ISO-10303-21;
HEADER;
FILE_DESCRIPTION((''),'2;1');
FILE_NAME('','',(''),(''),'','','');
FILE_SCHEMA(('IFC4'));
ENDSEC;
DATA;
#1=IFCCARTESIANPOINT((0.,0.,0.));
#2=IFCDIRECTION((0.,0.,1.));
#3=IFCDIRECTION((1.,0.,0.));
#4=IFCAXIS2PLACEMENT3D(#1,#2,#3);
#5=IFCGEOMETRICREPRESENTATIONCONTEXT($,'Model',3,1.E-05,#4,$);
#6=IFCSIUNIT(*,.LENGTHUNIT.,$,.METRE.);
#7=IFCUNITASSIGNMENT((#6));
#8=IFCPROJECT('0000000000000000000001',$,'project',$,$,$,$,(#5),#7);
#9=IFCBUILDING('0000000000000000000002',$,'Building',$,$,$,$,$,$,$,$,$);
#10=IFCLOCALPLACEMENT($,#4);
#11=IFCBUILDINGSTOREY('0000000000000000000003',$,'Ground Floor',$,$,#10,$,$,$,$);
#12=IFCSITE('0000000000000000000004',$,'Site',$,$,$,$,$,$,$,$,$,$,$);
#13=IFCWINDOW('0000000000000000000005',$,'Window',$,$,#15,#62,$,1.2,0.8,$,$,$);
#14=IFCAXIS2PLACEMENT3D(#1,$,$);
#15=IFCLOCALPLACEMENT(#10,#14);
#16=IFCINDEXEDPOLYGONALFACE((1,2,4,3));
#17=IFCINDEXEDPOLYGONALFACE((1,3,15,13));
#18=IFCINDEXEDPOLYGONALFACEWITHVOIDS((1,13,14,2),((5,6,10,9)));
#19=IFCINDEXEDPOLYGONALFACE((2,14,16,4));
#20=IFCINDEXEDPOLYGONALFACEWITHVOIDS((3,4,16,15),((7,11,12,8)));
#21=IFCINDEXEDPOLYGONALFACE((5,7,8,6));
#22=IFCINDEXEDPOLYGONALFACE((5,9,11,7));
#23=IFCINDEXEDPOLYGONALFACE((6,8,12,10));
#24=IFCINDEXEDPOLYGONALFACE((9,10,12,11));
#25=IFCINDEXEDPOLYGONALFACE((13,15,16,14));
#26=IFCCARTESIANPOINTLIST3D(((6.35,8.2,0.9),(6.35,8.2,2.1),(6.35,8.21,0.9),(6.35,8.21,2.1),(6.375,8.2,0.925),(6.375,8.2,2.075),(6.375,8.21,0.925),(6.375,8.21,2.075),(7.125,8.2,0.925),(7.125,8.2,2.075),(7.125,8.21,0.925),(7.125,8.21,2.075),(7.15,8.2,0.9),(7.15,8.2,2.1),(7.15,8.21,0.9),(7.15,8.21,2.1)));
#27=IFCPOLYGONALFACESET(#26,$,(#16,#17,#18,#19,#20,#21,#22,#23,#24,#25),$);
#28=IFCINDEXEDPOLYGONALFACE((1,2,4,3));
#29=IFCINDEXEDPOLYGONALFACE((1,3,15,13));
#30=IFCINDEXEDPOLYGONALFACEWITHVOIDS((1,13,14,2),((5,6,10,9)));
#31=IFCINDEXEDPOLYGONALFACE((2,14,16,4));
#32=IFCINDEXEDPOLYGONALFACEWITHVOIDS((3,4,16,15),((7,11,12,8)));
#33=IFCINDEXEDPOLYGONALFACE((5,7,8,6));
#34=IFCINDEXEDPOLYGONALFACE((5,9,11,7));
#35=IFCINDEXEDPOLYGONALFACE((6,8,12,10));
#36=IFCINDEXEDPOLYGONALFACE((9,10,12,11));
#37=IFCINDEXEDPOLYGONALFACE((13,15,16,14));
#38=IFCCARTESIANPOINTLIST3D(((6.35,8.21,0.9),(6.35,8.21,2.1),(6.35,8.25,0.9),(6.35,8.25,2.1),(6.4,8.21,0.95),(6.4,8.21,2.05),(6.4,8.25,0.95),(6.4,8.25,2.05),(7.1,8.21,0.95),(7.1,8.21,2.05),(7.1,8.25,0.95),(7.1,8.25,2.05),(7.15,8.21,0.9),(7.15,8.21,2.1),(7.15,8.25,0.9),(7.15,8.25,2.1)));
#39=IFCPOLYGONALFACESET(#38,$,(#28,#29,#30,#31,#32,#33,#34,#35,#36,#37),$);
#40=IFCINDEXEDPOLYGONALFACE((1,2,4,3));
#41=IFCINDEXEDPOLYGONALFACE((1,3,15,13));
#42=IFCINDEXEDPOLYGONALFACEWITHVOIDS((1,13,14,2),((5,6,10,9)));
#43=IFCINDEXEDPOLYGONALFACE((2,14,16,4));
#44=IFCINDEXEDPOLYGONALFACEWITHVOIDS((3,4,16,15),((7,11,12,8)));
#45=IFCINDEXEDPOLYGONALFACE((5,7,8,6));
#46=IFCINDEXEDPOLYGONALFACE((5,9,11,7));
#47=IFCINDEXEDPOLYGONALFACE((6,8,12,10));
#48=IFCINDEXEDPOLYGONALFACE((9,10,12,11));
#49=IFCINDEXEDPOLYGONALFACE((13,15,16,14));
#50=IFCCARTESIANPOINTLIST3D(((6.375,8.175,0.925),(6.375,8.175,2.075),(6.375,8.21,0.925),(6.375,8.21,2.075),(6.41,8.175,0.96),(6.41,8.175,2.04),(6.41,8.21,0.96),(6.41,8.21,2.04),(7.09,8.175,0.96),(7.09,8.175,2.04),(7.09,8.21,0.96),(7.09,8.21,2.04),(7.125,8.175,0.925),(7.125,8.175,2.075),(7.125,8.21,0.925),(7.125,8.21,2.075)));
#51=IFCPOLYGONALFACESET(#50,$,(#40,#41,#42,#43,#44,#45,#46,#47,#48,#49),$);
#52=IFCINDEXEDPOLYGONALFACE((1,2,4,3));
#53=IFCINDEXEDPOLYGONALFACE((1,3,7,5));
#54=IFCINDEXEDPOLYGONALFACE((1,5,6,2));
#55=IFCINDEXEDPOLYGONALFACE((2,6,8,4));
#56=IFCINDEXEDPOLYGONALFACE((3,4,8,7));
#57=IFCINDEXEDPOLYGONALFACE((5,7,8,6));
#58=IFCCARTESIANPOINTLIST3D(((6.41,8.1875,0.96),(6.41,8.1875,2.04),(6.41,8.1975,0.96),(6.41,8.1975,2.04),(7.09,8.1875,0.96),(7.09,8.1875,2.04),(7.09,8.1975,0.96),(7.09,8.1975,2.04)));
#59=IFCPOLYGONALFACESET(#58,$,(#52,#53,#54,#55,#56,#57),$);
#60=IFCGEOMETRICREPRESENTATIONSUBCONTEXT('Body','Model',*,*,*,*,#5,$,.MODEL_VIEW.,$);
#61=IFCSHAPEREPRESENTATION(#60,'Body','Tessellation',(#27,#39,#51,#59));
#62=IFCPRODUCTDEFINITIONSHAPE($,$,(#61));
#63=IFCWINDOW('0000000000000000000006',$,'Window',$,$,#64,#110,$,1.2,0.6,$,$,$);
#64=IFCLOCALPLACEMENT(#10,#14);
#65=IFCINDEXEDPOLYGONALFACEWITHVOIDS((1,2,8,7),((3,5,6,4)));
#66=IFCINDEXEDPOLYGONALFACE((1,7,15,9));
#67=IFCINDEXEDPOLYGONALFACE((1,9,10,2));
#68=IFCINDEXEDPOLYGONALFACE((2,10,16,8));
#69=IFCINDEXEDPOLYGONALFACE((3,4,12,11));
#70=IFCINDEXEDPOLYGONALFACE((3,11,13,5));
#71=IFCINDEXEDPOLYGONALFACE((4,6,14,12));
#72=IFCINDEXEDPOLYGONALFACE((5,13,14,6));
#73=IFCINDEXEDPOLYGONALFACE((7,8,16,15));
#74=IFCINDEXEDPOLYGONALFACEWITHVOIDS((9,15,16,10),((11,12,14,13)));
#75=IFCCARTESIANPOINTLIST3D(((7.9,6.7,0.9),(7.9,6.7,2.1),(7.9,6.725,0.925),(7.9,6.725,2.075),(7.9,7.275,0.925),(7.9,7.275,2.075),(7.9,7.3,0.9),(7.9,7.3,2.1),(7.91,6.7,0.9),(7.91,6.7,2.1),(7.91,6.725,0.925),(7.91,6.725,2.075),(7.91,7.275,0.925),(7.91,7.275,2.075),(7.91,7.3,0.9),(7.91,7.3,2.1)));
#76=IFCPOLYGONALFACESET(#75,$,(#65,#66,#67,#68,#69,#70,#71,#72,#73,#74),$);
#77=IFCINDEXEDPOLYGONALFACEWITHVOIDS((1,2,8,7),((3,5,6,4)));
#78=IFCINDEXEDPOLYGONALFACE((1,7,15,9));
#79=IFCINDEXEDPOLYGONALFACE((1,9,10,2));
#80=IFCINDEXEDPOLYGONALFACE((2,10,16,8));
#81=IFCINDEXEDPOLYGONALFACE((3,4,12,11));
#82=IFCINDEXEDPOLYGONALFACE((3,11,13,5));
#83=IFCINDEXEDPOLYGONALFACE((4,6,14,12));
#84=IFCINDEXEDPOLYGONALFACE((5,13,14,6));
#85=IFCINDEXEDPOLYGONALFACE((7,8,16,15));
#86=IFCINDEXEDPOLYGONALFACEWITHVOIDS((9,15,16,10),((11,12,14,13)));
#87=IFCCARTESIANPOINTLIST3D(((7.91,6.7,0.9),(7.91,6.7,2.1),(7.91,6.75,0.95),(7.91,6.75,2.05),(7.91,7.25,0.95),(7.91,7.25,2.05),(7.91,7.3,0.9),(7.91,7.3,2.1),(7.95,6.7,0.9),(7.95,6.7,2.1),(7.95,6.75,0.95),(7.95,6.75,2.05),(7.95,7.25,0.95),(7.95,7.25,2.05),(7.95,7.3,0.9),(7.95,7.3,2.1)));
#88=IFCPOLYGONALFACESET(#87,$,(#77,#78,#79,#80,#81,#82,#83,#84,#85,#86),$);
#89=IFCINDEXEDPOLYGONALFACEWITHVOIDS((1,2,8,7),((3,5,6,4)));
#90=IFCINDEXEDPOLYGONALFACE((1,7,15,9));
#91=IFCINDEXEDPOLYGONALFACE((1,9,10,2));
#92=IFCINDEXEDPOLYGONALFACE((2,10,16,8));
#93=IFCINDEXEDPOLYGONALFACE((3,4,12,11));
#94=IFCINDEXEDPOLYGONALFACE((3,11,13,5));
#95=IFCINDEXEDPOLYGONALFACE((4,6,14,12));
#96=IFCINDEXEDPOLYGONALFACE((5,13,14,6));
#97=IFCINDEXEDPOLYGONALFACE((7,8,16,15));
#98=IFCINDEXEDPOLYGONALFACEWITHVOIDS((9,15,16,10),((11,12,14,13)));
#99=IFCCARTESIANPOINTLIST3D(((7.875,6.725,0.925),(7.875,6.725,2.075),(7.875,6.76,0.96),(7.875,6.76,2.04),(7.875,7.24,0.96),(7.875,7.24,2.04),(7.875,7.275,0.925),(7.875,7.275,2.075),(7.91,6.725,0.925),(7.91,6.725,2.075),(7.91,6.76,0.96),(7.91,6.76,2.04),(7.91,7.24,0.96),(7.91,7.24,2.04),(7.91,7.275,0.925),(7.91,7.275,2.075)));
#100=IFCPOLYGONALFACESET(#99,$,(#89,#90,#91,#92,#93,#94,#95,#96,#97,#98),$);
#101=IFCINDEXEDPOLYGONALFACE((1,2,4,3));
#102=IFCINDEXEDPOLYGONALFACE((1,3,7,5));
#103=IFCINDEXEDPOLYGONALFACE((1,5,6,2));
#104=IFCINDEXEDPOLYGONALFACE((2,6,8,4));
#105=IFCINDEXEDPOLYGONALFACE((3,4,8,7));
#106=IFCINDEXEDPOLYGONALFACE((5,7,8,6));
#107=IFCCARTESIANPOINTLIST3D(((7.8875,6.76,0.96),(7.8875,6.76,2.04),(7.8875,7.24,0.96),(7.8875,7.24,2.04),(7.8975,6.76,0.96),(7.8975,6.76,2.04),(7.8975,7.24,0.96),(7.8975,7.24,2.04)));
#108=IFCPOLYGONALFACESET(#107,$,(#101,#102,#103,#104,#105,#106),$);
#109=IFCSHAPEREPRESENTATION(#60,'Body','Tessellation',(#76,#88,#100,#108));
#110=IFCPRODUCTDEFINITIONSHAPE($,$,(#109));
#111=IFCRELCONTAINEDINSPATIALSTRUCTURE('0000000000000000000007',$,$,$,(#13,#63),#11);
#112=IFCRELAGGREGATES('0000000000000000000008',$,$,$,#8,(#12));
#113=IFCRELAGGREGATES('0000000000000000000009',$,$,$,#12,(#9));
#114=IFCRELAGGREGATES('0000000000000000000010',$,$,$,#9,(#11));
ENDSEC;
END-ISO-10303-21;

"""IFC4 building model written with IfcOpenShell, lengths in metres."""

from ifc_helpers import new_model, si_unit, frame, origin_with_axes, place, context, subcontext, project, spatial, line, indexed_curve, outline, extrude, element, save


model = new_model("IFC4")

# Units and contexts
model_context = context("Model", 3, precision=1e-05, world=origin_with_axes())
body_context = subcontext(model_context, "Body", "Model", "MODEL_VIEW")
ifc_project = project(units=[si_unit("LENGTHUNIT", "METRE")], contexts=[model_context])

# Site, building, storey
site = spatial("IfcSite", under=ifc_project, Name="Site")
building = spatial("IfcBuilding", under=site, Name="Building")
storey_placement = place(None, origin_with_axes())
storey = spatial("IfcBuildingStorey", under=building, at=storey_placement, Name="Ground Floor")

# Windows
window_1_placement = place(storey_placement, frame((7.15, 8.3, 0.9), z_axis=(0.0, 0.0, 1.0), x_axis=(-1.0, 0.0, 0.0)))
element("IfcWindow", 1, at=window_1_placement, inside=storey, Name="Window", OverallHeight=1.2, OverallWidth=0.8, context=body_context, shape_type="SweptSolid", body=[
    extrude(outline(indexed_curve([(0.0, 0.0), (0.8, 0.0), (0.8, 1.2), (0.0, 1.2)], segments=[line(1, 2, 3, 4, 1)]), holes=[indexed_curve([(0.025, 0.025), (0.775, 0.025), (0.775, 1.175), (0.025, 1.175)], segments=[line(1, 2, 3, 4, 1)])]), frame((0.0, 0.09, 0.0), z_axis=(0.0, -1.0, 0.0), x_axis=(1.0, 0.0, 0.0)), (0.0, 0.0, -1.0), 0.01),
    extrude(outline(indexed_curve([(0.0, 0.0), (0.8, 0.0), (0.8, 1.2), (0.0, 1.2)], segments=[line(1, 2, 3, 4, 1)]), holes=[indexed_curve([(0.05, 0.05), (0.75, 0.05), (0.75, 1.15), (0.05, 1.15)], segments=[line(1, 2, 3, 4, 1)])]), frame((0.0, 0.05, 0.0), z_axis=(0.0, -1.0, 0.0), x_axis=(1.0, 0.0, 0.0)), (0.0, 0.0, -1.0), 0.04),
    extrude(outline(indexed_curve([(0.0, 0.0), (0.75, 0.0), (0.75, 1.15), (0.0, 1.15)], segments=[line(1, 2, 3, 4, 1)]), holes=[indexed_curve([(0.035, 0.035), (0.715, 0.035), (0.715, 1.115), (0.035, 1.115)], segments=[line(1, 2, 3, 4, 1)])]), frame((0.025, 0.09, 0.025), z_axis=(0.0, -1.0, 0.0), x_axis=(1.0, 0.0, 0.0)), (0.0, 0.0, -1.0), 0.035),
    extrude(outline(indexed_curve([(0.035, 0.035), (0.715, 0.035), (0.715, 1.115), (0.035, 1.115)], segments=[line(1, 2, 3, 4, 1)])), frame((0.025, 0.1025, 0.025), z_axis=(0.0, -1.0, 0.0), x_axis=(1.0, 0.0, 0.0)), (0.0, 0.0, -1.0), 0.01),
])
window_2_placement = place(storey_placement, frame((8.0, 6.7, 0.9), z_axis=(0.0, 0.0, 1.0), x_axis=(0.0, 1.0, 0.0)))
element("IfcWindow", 2, at=window_2_placement, inside=storey, Name="Window", OverallHeight=1.2, OverallWidth=0.6, context=body_context, shape_type="SweptSolid", body=[
    extrude(outline(indexed_curve([(0.0, 0.0), (0.6, 0.0), (0.6, 1.2), (0.0, 1.2)], segments=[line(1, 2, 3, 4, 1)]), holes=[indexed_curve([(0.025, 0.025), (0.575, 0.025), (0.575, 1.175), (0.025, 1.175)], segments=[line(1, 2, 3, 4, 1)])]), frame((0.0, 0.09, 0.0), z_axis=(0.0, -1.0, 0.0), x_axis=(1.0, 0.0, 0.0)), (0.0, 0.0, -1.0), 0.01),
    extrude(outline(indexed_curve([(0.0, 0.0), (0.6, 0.0), (0.6, 1.2), (0.0, 1.2)], segments=[line(1, 2, 3, 4, 1)]), holes=[indexed_curve([(0.05, 0.05), (0.55, 0.05), (0.55, 1.15), (0.05, 1.15)], segments=[line(1, 2, 3, 4, 1)])]), frame((0.0, 0.05, 0.0), z_axis=(0.0, -1.0, 0.0), x_axis=(1.0, 0.0, 0.0)), (0.0, 0.0, -1.0), 0.04),
    extrude(outline(indexed_curve([(0.0, 0.0), (0.55, 0.0), (0.55, 1.15), (0.0, 1.15)], segments=[line(1, 2, 3, 4, 1)]), holes=[indexed_curve([(0.035, 0.035), (0.515, 0.035), (0.515, 1.115), (0.035, 1.115)], segments=[line(1, 2, 3, 4, 1)])]), frame((0.025, 0.09, 0.025), z_axis=(0.0, -1.0, 0.0), x_axis=(1.0, 0.0, 0.0)), (0.0, 0.0, -1.0), 0.035),
    extrude(outline(indexed_curve([(0.035, 0.035), (0.515, 0.035), (0.515, 1.115), (0.035, 1.115)], segments=[line(1, 2, 3, 4, 1)])), frame((0.025, 0.1025, 0.025), z_axis=(0.0, -1.0, 0.0), x_axis=(1.0, 0.0, 0.0)), (0.0, 0.0, -1.0), 0.01),
])

save(model, "model.ifc")
